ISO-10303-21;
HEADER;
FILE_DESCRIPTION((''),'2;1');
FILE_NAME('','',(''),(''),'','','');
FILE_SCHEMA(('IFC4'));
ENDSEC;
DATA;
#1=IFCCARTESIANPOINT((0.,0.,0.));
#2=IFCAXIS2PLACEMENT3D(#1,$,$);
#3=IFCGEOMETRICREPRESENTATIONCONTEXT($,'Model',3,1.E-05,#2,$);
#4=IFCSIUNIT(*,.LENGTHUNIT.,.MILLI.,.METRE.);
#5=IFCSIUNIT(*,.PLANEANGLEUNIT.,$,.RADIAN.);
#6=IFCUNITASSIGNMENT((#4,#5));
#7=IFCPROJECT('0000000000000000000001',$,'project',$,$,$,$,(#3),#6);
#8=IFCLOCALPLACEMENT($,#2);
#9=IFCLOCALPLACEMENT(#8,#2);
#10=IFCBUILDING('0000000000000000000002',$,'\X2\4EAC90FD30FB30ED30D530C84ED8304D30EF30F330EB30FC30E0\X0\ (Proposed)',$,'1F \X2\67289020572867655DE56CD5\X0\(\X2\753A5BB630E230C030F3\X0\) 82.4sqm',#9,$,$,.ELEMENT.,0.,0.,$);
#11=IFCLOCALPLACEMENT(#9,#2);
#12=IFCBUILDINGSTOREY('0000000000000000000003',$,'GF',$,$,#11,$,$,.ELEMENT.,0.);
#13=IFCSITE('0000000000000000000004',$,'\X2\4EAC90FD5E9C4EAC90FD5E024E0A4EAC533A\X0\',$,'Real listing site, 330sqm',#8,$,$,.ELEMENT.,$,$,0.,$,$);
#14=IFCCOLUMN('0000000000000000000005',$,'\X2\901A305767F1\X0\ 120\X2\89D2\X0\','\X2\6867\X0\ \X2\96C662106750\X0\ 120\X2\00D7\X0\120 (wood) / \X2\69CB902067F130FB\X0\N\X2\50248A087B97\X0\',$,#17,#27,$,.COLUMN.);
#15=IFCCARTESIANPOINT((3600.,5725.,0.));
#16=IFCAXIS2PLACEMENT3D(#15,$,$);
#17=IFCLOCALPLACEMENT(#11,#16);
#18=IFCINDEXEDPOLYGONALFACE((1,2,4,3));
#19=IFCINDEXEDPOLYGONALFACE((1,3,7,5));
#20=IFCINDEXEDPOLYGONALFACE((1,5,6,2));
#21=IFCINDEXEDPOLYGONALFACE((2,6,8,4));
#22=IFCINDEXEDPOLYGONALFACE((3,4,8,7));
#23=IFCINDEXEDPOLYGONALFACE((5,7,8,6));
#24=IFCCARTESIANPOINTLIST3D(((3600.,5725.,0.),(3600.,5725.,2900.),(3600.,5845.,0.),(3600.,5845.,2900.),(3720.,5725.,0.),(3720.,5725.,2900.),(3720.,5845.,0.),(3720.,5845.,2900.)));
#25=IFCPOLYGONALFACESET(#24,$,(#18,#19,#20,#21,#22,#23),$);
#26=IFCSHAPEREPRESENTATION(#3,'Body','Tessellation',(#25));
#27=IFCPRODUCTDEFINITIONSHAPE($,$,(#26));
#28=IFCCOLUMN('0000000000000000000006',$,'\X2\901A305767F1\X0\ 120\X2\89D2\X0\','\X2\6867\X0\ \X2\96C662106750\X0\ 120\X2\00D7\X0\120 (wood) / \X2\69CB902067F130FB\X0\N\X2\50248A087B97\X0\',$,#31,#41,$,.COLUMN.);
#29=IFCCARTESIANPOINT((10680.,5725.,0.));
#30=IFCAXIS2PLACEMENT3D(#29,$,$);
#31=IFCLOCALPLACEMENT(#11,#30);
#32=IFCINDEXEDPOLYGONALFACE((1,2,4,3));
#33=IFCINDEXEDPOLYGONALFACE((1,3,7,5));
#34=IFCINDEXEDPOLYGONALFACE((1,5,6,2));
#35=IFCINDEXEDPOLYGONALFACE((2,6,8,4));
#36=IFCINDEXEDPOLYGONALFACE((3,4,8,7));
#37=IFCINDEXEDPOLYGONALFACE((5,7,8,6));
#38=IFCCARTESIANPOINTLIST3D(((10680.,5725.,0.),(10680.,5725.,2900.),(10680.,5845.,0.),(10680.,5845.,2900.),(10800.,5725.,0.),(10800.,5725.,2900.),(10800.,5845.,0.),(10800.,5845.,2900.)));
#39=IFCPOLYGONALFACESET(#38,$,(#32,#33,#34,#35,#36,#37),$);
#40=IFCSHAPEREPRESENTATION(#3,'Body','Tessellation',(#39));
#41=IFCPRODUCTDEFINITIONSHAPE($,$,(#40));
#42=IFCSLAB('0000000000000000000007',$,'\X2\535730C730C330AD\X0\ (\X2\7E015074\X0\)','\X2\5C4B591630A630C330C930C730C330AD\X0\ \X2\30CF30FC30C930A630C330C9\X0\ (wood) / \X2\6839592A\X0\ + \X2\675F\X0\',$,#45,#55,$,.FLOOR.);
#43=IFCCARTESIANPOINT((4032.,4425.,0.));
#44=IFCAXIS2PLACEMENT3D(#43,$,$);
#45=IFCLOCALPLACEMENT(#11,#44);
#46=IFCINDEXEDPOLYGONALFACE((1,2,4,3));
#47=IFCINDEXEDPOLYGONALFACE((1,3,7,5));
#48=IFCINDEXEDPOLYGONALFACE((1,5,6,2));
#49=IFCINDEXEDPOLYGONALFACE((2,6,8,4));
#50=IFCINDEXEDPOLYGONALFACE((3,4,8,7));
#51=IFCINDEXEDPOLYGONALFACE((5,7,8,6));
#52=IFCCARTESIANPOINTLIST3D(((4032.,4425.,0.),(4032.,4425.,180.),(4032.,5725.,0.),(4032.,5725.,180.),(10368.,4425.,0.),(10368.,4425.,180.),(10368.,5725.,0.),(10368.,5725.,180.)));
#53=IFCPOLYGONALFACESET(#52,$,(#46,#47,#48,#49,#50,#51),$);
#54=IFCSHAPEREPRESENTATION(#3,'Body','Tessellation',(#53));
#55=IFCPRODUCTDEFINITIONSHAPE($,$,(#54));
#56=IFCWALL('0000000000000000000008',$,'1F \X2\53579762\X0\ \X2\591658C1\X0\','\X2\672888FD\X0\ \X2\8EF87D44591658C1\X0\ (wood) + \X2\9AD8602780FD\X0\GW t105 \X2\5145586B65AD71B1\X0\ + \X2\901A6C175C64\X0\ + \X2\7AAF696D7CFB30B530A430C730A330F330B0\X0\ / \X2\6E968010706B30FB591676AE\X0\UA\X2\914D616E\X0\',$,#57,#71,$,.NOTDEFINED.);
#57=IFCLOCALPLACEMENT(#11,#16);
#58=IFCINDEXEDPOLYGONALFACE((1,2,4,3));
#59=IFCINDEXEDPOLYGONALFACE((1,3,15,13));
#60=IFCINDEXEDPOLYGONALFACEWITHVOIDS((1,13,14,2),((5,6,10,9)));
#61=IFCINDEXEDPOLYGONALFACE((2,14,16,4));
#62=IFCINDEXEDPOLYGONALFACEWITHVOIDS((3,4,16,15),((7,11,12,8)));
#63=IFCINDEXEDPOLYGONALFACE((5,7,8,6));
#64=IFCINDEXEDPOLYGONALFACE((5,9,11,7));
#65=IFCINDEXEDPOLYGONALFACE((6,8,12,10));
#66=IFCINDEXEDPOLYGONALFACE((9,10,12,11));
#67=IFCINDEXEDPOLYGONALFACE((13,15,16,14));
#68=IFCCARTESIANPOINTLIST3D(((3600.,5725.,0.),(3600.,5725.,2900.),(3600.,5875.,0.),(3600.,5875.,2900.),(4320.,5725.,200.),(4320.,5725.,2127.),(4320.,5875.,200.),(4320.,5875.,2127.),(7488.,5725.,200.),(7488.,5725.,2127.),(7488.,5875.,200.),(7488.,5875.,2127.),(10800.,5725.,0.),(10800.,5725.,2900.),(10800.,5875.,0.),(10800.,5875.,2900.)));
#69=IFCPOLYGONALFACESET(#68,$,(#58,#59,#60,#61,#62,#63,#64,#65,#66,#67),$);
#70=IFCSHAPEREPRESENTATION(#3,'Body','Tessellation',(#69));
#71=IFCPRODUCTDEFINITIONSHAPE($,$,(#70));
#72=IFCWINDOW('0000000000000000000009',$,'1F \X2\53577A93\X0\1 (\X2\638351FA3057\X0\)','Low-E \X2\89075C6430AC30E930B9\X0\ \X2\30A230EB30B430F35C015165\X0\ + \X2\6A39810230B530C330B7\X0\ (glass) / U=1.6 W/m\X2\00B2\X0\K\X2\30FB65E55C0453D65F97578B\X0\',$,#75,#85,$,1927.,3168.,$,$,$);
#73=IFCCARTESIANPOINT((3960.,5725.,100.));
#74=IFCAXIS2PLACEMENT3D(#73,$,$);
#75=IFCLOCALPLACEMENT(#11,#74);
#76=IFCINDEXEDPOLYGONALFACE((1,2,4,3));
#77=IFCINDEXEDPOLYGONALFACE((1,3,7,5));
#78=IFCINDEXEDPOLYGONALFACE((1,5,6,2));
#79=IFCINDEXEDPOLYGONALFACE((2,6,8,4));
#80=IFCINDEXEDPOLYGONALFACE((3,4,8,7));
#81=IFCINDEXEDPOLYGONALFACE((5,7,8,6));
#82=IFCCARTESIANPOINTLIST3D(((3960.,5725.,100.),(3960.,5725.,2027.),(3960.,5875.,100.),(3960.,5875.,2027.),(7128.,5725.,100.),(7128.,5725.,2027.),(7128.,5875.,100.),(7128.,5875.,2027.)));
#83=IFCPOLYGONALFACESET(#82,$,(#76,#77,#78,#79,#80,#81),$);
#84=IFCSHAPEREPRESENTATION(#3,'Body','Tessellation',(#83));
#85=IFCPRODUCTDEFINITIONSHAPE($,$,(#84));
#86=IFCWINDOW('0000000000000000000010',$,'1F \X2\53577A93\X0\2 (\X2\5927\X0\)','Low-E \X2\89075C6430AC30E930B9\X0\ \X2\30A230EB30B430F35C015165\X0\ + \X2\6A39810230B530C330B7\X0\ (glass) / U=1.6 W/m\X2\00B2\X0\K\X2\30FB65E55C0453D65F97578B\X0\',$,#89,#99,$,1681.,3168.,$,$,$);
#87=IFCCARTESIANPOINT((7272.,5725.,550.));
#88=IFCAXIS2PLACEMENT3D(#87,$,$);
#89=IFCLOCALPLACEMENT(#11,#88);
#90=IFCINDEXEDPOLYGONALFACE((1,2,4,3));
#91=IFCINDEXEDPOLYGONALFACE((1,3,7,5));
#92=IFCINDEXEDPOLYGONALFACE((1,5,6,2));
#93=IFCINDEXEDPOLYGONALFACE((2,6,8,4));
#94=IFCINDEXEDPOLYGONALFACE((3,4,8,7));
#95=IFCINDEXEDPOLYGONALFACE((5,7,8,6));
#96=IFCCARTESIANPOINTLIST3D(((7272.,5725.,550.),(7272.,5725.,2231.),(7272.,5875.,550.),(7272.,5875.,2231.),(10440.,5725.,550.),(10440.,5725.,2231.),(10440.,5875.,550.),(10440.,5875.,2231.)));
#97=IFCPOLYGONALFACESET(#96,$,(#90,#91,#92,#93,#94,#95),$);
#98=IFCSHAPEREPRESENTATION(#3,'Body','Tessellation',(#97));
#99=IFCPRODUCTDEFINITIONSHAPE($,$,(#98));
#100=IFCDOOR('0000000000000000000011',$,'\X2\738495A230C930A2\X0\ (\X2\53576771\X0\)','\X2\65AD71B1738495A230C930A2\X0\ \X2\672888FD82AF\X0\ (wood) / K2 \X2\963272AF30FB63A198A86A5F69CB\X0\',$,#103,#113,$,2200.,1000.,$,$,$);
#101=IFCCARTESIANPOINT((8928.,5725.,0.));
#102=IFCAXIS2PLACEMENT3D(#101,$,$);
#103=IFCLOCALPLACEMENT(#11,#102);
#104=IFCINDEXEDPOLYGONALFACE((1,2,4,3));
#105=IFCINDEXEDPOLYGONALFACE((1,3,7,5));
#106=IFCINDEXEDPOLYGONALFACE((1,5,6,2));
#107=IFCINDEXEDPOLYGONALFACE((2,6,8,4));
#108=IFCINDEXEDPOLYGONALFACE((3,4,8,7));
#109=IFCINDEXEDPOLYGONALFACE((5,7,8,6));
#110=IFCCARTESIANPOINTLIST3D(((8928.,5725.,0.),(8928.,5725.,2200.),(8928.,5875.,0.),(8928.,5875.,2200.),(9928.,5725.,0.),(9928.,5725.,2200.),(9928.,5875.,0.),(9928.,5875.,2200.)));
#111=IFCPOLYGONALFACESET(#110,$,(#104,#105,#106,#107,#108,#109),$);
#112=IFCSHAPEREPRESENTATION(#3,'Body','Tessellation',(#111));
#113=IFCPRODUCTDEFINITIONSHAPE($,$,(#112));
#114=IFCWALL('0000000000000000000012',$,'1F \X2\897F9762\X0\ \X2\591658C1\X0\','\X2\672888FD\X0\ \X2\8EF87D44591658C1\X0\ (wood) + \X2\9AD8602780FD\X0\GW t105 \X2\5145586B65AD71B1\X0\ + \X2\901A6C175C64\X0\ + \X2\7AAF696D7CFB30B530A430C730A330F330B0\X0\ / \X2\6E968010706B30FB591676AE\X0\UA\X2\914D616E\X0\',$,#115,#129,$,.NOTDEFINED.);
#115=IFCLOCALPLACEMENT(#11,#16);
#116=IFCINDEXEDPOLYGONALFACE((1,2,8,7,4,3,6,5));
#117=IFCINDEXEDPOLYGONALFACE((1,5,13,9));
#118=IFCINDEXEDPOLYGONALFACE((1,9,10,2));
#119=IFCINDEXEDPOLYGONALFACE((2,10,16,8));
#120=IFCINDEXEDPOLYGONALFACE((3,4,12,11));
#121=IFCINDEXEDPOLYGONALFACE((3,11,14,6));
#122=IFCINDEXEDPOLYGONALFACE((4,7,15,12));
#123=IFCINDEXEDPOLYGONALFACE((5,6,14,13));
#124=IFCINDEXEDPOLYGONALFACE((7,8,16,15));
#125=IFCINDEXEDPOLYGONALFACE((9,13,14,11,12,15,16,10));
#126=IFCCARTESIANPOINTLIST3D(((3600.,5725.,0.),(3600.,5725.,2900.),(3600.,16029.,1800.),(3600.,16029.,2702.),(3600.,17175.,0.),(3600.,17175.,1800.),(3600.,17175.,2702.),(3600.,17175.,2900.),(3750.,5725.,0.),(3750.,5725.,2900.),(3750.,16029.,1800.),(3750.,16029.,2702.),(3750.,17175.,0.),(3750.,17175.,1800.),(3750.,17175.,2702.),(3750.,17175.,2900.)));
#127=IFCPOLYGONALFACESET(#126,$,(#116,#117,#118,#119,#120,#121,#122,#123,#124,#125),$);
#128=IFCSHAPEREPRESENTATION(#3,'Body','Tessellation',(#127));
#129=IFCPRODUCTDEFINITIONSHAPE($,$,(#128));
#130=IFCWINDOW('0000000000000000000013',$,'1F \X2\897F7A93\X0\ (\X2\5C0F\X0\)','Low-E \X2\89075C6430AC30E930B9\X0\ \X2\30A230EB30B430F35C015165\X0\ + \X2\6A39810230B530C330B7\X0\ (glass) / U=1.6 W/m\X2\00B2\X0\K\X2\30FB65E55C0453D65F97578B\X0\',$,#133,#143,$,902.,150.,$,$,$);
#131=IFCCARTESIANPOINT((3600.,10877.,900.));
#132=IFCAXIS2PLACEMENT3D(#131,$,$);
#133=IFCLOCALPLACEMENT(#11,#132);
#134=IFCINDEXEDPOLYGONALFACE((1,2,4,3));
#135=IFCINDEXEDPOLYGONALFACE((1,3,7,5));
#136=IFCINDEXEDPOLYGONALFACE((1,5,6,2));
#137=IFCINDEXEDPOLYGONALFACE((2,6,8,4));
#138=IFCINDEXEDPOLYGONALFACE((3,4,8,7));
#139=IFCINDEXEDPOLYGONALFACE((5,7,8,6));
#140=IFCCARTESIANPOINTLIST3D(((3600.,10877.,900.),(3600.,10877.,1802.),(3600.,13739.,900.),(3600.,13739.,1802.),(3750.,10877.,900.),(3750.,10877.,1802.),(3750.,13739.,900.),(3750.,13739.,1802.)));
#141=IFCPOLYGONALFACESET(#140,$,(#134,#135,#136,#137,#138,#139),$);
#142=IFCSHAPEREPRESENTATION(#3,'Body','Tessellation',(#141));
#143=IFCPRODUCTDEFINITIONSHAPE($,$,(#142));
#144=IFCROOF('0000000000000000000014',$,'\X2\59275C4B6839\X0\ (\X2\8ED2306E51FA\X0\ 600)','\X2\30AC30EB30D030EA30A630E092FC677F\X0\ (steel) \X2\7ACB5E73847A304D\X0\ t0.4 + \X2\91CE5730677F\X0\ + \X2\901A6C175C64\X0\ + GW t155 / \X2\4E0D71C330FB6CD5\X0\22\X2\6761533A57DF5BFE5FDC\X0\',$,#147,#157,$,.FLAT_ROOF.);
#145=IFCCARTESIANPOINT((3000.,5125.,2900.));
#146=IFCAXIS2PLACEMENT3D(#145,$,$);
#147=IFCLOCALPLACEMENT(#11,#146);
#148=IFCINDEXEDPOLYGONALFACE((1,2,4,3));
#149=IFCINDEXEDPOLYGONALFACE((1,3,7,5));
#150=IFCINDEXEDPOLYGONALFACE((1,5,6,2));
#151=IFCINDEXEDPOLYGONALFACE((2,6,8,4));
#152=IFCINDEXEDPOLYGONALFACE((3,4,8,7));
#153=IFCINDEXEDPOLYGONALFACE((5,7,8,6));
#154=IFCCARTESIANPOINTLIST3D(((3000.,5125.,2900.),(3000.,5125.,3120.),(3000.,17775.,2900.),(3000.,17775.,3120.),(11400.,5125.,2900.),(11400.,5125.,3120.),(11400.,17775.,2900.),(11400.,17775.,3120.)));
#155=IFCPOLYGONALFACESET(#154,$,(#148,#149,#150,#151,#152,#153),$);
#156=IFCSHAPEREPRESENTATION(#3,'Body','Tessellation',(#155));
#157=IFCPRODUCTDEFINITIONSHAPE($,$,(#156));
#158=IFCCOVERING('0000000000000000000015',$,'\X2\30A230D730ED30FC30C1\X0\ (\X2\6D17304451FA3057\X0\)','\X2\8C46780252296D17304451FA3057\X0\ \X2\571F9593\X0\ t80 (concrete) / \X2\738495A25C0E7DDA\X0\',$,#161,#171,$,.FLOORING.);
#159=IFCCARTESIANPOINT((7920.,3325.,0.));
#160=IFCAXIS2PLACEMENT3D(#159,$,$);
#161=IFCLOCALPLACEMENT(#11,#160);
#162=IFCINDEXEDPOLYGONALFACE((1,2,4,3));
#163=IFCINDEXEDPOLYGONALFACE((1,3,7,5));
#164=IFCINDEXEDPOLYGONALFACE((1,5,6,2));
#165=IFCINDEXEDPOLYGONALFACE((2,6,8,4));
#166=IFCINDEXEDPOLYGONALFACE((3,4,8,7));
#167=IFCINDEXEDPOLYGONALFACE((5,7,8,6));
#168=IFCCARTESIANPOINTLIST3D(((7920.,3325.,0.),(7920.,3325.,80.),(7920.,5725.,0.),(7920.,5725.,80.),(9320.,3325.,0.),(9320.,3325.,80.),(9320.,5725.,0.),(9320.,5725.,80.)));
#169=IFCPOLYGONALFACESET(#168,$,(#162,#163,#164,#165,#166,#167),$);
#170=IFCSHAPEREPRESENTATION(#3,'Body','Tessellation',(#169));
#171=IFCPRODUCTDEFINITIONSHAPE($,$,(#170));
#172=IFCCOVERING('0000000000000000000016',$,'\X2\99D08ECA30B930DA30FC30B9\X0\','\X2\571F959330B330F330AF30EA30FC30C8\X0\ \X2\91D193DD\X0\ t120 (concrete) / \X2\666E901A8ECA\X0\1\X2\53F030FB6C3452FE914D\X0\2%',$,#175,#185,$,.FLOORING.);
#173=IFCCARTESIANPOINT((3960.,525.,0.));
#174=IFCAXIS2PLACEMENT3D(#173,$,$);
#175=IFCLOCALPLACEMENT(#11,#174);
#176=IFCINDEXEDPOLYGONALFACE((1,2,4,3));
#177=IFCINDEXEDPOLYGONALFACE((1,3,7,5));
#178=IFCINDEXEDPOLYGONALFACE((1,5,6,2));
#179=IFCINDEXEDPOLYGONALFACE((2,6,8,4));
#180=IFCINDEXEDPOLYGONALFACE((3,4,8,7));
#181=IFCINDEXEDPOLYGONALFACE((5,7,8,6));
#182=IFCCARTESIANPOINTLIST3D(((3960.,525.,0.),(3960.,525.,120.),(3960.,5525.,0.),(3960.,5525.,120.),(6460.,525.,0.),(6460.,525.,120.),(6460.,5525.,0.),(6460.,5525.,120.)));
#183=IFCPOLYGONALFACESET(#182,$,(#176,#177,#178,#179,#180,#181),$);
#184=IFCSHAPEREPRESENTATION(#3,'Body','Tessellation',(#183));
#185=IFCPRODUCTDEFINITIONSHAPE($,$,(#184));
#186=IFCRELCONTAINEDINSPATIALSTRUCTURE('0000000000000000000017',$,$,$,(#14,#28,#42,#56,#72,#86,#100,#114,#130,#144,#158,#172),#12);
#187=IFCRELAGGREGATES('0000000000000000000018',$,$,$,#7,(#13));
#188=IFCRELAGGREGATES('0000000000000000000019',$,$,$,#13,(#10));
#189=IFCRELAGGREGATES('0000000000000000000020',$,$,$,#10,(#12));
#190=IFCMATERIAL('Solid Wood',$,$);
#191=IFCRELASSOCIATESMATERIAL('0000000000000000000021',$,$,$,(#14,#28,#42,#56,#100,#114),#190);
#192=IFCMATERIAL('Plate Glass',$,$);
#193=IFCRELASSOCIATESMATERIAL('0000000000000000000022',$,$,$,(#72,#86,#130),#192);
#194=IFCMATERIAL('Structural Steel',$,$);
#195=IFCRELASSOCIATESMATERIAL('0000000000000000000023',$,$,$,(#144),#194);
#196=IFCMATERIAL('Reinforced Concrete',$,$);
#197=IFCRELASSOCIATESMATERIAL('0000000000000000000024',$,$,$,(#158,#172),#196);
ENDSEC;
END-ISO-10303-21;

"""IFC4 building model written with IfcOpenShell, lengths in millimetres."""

from ifc_helpers import new_model, si_unit, frame, frame_2d, origin, place, context, project, spatial, rectangle, extrude, material, element, fill, save


model = new_model("IFC4")

# Units and contexts
model_context = context("Model", 3, precision=1e-05, world=origin())
ifc_project = project(units=[si_unit("LENGTHUNIT", "METRE", prefix="MILLI"), si_unit("PLANEANGLEUNIT", "RADIAN")], contexts=[model_context])

# Site, building, storey
site_placement = place(None, origin())
site = spatial("IfcSite", under=ifc_project, at=site_placement, Name="京都府京都市上京区", ObjectType="Real listing site, 330sqm", CompositionType="ELEMENT", RefElevation=0.0)
building_placement = place(site_placement, origin())
building = spatial("IfcBuilding", under=site, at=building_placement, Name="京都・ロフト付きワンルーム (Proposed)", ObjectType="1F 木造在来工法(町家モダン) 82.4sqm", CompositionType="ELEMENT", ElevationOfRefHeight=0.0, ElevationOfTerrain=0.0)
storey_placement = place(building_placement, origin())
storey = spatial("IfcBuildingStorey", under=building, at=storey_placement, Name="GF", CompositionType="ELEMENT", Elevation=0.0)

# Columns
ifc_material_1 = material(Name="Solid Wood")
column_1_placement = place(storey_placement, frame((3600.0, 5725.0, 0.0)))
element("IfcColumn", 1, at=column_1_placement, inside=storey, material=ifc_material_1, Name="通し柱 120角", Description="桧 集成材 120×120 (wood) / 構造柱・N値計算", PredefinedType="COLUMN", context=model_context, shape_type="SweptSolid", body=[
    extrude(rectangle(XDim=120.0, YDim=120.0, at=frame_2d((60.0, 60.0))), frame((3600.0, 5725.0, 0.0)), (0.0, 0.0, 1.0), 2900.0),
])
column_2_placement = place(storey_placement, frame((10680.0, 5725.0, 0.0)))
element("IfcColumn", 2, at=column_2_placement, inside=storey, material=ifc_material_1, Name="通し柱 120角", Description="桧 集成材 120×120 (wood) / 構造柱・N値計算", PredefinedType="COLUMN", context=model_context, shape_type="SweptSolid", body=[
    extrude(rectangle(XDim=120.0, YDim=120.0, at=frame_2d((60.0, 60.0))), frame((10680.0, 5725.0, 0.0)), (0.0, 0.0, 1.0), 2900.0),
])

# Slab
ifc_material_2 = material(Name="Reinforced Concrete")
slab_1_placement = place(storey_placement, frame((4032.0, 4425.0, 0.0)))
element("IfcSlab", 3, at=slab_1_placement, inside=storey, material=ifc_material_1, Name="南デッキ (縁側)", Description="屋外ウッドデッキ ハードウッド (wood) / 根太 + 束", PredefinedType="FLOOR", context=model_context, shape_type="SweptSolid", body=[
    extrude(rectangle(XDim=6336.0, YDim=1300.0, at=frame_2d((3168.0, 650.0))), frame((4032.0, 4425.0, 0.0)), (0.0, 0.0, 1.0), 180.0),
])

# Wall, openings, windows, door
wall_1_placement = place(storey_placement, frame((3600.0, 5725.0, 0.0)))
wall_1 = element("IfcWall", 4, at=wall_1_placement, inside=storey, material=ifc_material_1, Name="1F 南面 外壁", Description="木製 軸組外壁 (wood) + 高性能GW t105 充填断熱 + 通気層 + 窯業系サイディング / 準耐火・外皮UA配慮", PredefinedType="NOTDEFINED", context=model_context, shape_type="SweptSolid", body=[
    extrude(rectangle(XDim=7200.0, YDim=150.0, at=frame_2d((3600.0, 75.0))), frame((3600.0, 5725.0, 0.0)), (0.0, 0.0, 1.0), 2900.0),
])
opening_1_placement = place(storey_placement, frame((3960.0, 5725.0, 100.0)))
opening_1 = element("IfcOpeningElement", 5, at=opening_1_placement, cuts=wall_1, PredefinedType="NOTDEFINED", context=model_context, shape_type="SweptSolid", body=[
    extrude(rectangle(XDim=3168.0, YDim=150.0, at=frame_2d((1584.0, 75.0))), frame((3960.0, 5725.0, 100.0)), (0.0, 0.0, 1.0), 1927.0),
])
opening_2_placement = place(storey_placement, frame((7272.0, 5725.0, 550.0)))
opening_2 = element("IfcOpeningElement", 6, at=opening_2_placement, cuts=wall_1, PredefinedType="NOTDEFINED", context=model_context, shape_type="SweptSolid", body=[
    extrude(rectangle(XDim=3168.0, YDim=150.0, at=frame_2d((1584.0, 75.0))), frame((7272.0, 5725.0, 550.0)), (0.0, 0.0, 1.0), 1681.0),
])
opening_3_placement = place(storey_placement, frame((8928.0, 5725.0, 0.0)))
opening_3 = element("IfcOpeningElement", 7, at=opening_3_placement, cuts=wall_1, PredefinedType="NOTDEFINED", context=model_context, shape_type="SweptSolid", body=[
    extrude(rectangle(XDim=1000.0, YDim=150.0, at=frame_2d((500.0, 75.0))), frame((8928.0, 5725.0, 0.0)), (0.0, 0.0, 1.0), 2200.0),
])
ifc_material_3 = material(Name="Plate Glass")
window_1_placement = place(storey_placement, frame((3960.0, 5725.0, 100.0)))
window_1 = element("IfcWindow", 8, at=window_1_placement, inside=storey, material=ifc_material_3, Name="1F 南窓1 (掃出し)", Description="Low-E 複層ガラス アルゴン封入 + 樹脂サッシ (glass) / U=1.6 W/m²K・日射取得型", OverallHeight=1927.0, OverallWidth=3168.0, context=model_context, shape_type="SweptSolid", body=[
    extrude(rectangle(XDim=3168.0, YDim=150.0, at=frame_2d((1584.0, 75.0))), frame((3960.0, 5725.0, 100.0)), (0.0, 0.0, 1.0), 1927.0),
])
fill(opening_1, window_1)
window_2_placement = place(storey_placement, frame((7272.0, 5725.0, 550.0)))
window_2 = element("IfcWindow", 9, at=window_2_placement, inside=storey, material=ifc_material_3, Name="1F 南窓2 (大)", Description="Low-E 複層ガラス アルゴン封入 + 樹脂サッシ (glass) / U=1.6 W/m²K・日射取得型", OverallHeight=1681.0, OverallWidth=3168.0, context=model_context, shape_type="SweptSolid", body=[
    extrude(rectangle(XDim=3168.0, YDim=150.0, at=frame_2d((1584.0, 75.0))), frame((7272.0, 5725.0, 550.0)), (0.0, 0.0, 1.0), 1681.0),
])
fill(opening_2, window_2)
door_placement = place(storey_placement, frame((8928.0, 5725.0, 0.0)))
door = element("IfcDoor", 10, at=door_placement, inside=storey, material=ifc_material_1, Name="玄関ドア (南東)", Description="断熱玄関ドア 木製芯 (wood) / K2 防犯・採風機構", OverallHeight=2200.0, OverallWidth=1000.0, context=model_context, shape_type="SweptSolid", body=[
    extrude(rectangle(XDim=1000.0, YDim=150.0, at=frame_2d((500.0, 75.0))), frame((8928.0, 5725.0, 0.0)), (0.0, 0.0, 1.0), 2200.0),
])
fill(opening_3, door)

# Wall, opening, window
wall_2_placement = place(storey_placement, frame((3600.0, 5725.0, 0.0)))
wall_2 = element("IfcWall", 11, at=wall_2_placement, inside=storey, material=ifc_material_1, Name="1F 西面 外壁", Description="木製 軸組外壁 (wood) + 高性能GW t105 充填断熱 + 通気層 + 窯業系サイディング / 準耐火・外皮UA配慮", PredefinedType="NOTDEFINED", context=model_context, shape_type="SweptSolid", body=[
    extrude(rectangle(XDim=150.0, YDim=11450.0, at=frame_2d((75.0, 5725.0))), frame((3600.0, 5725.0, 0.0)), (0.0, 0.0, 1.0), 2900.0),
])
opening_4_placement = place(storey_placement, frame((3600.0, 10877.0, 900.0)))
opening_4 = element("IfcOpeningElement", 12, at=opening_4_placement, cuts=wall_2, PredefinedType="NOTDEFINED", context=model_context, shape_type="SweptSolid", body=[
    extrude(rectangle(XDim=150.0, YDim=2862.0, at=frame_2d((75.0, 1431.0))), frame((3600.0, 10877.0, 900.0)), (0.0, 0.0, 1.0), 902.0),
])
window_3_placement = place(storey_placement, frame((3600.0, 10877.0, 900.0)))
window_3 = element("IfcWindow", 13, at=window_3_placement, inside=storey, material=ifc_material_3, Name="1F 西窓 (小)", Description="Low-E 複層ガラス アルゴン封入 + 樹脂サッシ (glass) / U=1.6 W/m²K・日射取得型", OverallHeight=902.0, OverallWidth=150.0, context=model_context, shape_type="SweptSolid", body=[
    extrude(rectangle(XDim=150.0, YDim=2862.0, at=frame_2d((75.0, 1431.0))), frame((3600.0, 10877.0, 900.0)), (0.0, 0.0, 1.0), 902.0),
])
fill(opening_4, window_3)

# Roof
ifc_material_4 = material(Name="Structural Steel")
roof_placement = place(storey_placement, frame((3000.0, 5125.0, 2900.0)))
element("IfcRoof", 14, at=roof_placement, inside=storey, material=ifc_material_4, Name="大屋根 (軒の出 600)", Description="ガルバリウム鋼板 (steel) 立平葺き t0.4 + 野地板 + 通気層 + GW t155 / 不燃・法22条区域対応", PredefinedType="FLAT_ROOF", context=model_context, shape_type="SweptSolid", body=[
    extrude(rectangle(XDim=8400.0, YDim=12650.0, at=frame_2d((4200.0, 6325.0))), frame((3000.0, 5125.0, 2900.0)), (0.0, 0.0, 1.0), 220.0),
])

# Coverings
covering_1_placement = place(storey_placement, frame((7920.0, 3325.0, 0.0)))
element("IfcCovering", 15, at=covering_1_placement, inside=storey, material=ifc_material_2, Name="アプローチ (洗い出し)", Description="豆砂利洗い出し 土間 t80 (concrete) / 玄関導線", PredefinedType="FLOORING", context=model_context, shape_type="SweptSolid", body=[
    extrude(rectangle(XDim=1400.0, YDim=2400.0, at=frame_2d((700.0, 1200.0))), frame((7920.0, 3325.0, 0.0)), (0.0, 0.0, 1.0), 80.0),
])
covering_2_placement = place(storey_placement, frame((3960.0, 525.0, 0.0)))
element("IfcCovering", 16, at=covering_2_placement, inside=storey, material=ifc_material_2, Name="駐車スペース", Description="土間コンクリート 金鏝 t120 (concrete) / 普通車1台・水勾配2%", PredefinedType="FLOORING", context=model_context, shape_type="SweptSolid", body=[
    extrude(rectangle(XDim=2500.0, YDim=5000.0, at=frame_2d((1250.0, 2500.0))), frame((3960.0, 525.0, 0.0)), (0.0, 0.0, 1.0), 120.0),
])

save(model, "model.ifc")
